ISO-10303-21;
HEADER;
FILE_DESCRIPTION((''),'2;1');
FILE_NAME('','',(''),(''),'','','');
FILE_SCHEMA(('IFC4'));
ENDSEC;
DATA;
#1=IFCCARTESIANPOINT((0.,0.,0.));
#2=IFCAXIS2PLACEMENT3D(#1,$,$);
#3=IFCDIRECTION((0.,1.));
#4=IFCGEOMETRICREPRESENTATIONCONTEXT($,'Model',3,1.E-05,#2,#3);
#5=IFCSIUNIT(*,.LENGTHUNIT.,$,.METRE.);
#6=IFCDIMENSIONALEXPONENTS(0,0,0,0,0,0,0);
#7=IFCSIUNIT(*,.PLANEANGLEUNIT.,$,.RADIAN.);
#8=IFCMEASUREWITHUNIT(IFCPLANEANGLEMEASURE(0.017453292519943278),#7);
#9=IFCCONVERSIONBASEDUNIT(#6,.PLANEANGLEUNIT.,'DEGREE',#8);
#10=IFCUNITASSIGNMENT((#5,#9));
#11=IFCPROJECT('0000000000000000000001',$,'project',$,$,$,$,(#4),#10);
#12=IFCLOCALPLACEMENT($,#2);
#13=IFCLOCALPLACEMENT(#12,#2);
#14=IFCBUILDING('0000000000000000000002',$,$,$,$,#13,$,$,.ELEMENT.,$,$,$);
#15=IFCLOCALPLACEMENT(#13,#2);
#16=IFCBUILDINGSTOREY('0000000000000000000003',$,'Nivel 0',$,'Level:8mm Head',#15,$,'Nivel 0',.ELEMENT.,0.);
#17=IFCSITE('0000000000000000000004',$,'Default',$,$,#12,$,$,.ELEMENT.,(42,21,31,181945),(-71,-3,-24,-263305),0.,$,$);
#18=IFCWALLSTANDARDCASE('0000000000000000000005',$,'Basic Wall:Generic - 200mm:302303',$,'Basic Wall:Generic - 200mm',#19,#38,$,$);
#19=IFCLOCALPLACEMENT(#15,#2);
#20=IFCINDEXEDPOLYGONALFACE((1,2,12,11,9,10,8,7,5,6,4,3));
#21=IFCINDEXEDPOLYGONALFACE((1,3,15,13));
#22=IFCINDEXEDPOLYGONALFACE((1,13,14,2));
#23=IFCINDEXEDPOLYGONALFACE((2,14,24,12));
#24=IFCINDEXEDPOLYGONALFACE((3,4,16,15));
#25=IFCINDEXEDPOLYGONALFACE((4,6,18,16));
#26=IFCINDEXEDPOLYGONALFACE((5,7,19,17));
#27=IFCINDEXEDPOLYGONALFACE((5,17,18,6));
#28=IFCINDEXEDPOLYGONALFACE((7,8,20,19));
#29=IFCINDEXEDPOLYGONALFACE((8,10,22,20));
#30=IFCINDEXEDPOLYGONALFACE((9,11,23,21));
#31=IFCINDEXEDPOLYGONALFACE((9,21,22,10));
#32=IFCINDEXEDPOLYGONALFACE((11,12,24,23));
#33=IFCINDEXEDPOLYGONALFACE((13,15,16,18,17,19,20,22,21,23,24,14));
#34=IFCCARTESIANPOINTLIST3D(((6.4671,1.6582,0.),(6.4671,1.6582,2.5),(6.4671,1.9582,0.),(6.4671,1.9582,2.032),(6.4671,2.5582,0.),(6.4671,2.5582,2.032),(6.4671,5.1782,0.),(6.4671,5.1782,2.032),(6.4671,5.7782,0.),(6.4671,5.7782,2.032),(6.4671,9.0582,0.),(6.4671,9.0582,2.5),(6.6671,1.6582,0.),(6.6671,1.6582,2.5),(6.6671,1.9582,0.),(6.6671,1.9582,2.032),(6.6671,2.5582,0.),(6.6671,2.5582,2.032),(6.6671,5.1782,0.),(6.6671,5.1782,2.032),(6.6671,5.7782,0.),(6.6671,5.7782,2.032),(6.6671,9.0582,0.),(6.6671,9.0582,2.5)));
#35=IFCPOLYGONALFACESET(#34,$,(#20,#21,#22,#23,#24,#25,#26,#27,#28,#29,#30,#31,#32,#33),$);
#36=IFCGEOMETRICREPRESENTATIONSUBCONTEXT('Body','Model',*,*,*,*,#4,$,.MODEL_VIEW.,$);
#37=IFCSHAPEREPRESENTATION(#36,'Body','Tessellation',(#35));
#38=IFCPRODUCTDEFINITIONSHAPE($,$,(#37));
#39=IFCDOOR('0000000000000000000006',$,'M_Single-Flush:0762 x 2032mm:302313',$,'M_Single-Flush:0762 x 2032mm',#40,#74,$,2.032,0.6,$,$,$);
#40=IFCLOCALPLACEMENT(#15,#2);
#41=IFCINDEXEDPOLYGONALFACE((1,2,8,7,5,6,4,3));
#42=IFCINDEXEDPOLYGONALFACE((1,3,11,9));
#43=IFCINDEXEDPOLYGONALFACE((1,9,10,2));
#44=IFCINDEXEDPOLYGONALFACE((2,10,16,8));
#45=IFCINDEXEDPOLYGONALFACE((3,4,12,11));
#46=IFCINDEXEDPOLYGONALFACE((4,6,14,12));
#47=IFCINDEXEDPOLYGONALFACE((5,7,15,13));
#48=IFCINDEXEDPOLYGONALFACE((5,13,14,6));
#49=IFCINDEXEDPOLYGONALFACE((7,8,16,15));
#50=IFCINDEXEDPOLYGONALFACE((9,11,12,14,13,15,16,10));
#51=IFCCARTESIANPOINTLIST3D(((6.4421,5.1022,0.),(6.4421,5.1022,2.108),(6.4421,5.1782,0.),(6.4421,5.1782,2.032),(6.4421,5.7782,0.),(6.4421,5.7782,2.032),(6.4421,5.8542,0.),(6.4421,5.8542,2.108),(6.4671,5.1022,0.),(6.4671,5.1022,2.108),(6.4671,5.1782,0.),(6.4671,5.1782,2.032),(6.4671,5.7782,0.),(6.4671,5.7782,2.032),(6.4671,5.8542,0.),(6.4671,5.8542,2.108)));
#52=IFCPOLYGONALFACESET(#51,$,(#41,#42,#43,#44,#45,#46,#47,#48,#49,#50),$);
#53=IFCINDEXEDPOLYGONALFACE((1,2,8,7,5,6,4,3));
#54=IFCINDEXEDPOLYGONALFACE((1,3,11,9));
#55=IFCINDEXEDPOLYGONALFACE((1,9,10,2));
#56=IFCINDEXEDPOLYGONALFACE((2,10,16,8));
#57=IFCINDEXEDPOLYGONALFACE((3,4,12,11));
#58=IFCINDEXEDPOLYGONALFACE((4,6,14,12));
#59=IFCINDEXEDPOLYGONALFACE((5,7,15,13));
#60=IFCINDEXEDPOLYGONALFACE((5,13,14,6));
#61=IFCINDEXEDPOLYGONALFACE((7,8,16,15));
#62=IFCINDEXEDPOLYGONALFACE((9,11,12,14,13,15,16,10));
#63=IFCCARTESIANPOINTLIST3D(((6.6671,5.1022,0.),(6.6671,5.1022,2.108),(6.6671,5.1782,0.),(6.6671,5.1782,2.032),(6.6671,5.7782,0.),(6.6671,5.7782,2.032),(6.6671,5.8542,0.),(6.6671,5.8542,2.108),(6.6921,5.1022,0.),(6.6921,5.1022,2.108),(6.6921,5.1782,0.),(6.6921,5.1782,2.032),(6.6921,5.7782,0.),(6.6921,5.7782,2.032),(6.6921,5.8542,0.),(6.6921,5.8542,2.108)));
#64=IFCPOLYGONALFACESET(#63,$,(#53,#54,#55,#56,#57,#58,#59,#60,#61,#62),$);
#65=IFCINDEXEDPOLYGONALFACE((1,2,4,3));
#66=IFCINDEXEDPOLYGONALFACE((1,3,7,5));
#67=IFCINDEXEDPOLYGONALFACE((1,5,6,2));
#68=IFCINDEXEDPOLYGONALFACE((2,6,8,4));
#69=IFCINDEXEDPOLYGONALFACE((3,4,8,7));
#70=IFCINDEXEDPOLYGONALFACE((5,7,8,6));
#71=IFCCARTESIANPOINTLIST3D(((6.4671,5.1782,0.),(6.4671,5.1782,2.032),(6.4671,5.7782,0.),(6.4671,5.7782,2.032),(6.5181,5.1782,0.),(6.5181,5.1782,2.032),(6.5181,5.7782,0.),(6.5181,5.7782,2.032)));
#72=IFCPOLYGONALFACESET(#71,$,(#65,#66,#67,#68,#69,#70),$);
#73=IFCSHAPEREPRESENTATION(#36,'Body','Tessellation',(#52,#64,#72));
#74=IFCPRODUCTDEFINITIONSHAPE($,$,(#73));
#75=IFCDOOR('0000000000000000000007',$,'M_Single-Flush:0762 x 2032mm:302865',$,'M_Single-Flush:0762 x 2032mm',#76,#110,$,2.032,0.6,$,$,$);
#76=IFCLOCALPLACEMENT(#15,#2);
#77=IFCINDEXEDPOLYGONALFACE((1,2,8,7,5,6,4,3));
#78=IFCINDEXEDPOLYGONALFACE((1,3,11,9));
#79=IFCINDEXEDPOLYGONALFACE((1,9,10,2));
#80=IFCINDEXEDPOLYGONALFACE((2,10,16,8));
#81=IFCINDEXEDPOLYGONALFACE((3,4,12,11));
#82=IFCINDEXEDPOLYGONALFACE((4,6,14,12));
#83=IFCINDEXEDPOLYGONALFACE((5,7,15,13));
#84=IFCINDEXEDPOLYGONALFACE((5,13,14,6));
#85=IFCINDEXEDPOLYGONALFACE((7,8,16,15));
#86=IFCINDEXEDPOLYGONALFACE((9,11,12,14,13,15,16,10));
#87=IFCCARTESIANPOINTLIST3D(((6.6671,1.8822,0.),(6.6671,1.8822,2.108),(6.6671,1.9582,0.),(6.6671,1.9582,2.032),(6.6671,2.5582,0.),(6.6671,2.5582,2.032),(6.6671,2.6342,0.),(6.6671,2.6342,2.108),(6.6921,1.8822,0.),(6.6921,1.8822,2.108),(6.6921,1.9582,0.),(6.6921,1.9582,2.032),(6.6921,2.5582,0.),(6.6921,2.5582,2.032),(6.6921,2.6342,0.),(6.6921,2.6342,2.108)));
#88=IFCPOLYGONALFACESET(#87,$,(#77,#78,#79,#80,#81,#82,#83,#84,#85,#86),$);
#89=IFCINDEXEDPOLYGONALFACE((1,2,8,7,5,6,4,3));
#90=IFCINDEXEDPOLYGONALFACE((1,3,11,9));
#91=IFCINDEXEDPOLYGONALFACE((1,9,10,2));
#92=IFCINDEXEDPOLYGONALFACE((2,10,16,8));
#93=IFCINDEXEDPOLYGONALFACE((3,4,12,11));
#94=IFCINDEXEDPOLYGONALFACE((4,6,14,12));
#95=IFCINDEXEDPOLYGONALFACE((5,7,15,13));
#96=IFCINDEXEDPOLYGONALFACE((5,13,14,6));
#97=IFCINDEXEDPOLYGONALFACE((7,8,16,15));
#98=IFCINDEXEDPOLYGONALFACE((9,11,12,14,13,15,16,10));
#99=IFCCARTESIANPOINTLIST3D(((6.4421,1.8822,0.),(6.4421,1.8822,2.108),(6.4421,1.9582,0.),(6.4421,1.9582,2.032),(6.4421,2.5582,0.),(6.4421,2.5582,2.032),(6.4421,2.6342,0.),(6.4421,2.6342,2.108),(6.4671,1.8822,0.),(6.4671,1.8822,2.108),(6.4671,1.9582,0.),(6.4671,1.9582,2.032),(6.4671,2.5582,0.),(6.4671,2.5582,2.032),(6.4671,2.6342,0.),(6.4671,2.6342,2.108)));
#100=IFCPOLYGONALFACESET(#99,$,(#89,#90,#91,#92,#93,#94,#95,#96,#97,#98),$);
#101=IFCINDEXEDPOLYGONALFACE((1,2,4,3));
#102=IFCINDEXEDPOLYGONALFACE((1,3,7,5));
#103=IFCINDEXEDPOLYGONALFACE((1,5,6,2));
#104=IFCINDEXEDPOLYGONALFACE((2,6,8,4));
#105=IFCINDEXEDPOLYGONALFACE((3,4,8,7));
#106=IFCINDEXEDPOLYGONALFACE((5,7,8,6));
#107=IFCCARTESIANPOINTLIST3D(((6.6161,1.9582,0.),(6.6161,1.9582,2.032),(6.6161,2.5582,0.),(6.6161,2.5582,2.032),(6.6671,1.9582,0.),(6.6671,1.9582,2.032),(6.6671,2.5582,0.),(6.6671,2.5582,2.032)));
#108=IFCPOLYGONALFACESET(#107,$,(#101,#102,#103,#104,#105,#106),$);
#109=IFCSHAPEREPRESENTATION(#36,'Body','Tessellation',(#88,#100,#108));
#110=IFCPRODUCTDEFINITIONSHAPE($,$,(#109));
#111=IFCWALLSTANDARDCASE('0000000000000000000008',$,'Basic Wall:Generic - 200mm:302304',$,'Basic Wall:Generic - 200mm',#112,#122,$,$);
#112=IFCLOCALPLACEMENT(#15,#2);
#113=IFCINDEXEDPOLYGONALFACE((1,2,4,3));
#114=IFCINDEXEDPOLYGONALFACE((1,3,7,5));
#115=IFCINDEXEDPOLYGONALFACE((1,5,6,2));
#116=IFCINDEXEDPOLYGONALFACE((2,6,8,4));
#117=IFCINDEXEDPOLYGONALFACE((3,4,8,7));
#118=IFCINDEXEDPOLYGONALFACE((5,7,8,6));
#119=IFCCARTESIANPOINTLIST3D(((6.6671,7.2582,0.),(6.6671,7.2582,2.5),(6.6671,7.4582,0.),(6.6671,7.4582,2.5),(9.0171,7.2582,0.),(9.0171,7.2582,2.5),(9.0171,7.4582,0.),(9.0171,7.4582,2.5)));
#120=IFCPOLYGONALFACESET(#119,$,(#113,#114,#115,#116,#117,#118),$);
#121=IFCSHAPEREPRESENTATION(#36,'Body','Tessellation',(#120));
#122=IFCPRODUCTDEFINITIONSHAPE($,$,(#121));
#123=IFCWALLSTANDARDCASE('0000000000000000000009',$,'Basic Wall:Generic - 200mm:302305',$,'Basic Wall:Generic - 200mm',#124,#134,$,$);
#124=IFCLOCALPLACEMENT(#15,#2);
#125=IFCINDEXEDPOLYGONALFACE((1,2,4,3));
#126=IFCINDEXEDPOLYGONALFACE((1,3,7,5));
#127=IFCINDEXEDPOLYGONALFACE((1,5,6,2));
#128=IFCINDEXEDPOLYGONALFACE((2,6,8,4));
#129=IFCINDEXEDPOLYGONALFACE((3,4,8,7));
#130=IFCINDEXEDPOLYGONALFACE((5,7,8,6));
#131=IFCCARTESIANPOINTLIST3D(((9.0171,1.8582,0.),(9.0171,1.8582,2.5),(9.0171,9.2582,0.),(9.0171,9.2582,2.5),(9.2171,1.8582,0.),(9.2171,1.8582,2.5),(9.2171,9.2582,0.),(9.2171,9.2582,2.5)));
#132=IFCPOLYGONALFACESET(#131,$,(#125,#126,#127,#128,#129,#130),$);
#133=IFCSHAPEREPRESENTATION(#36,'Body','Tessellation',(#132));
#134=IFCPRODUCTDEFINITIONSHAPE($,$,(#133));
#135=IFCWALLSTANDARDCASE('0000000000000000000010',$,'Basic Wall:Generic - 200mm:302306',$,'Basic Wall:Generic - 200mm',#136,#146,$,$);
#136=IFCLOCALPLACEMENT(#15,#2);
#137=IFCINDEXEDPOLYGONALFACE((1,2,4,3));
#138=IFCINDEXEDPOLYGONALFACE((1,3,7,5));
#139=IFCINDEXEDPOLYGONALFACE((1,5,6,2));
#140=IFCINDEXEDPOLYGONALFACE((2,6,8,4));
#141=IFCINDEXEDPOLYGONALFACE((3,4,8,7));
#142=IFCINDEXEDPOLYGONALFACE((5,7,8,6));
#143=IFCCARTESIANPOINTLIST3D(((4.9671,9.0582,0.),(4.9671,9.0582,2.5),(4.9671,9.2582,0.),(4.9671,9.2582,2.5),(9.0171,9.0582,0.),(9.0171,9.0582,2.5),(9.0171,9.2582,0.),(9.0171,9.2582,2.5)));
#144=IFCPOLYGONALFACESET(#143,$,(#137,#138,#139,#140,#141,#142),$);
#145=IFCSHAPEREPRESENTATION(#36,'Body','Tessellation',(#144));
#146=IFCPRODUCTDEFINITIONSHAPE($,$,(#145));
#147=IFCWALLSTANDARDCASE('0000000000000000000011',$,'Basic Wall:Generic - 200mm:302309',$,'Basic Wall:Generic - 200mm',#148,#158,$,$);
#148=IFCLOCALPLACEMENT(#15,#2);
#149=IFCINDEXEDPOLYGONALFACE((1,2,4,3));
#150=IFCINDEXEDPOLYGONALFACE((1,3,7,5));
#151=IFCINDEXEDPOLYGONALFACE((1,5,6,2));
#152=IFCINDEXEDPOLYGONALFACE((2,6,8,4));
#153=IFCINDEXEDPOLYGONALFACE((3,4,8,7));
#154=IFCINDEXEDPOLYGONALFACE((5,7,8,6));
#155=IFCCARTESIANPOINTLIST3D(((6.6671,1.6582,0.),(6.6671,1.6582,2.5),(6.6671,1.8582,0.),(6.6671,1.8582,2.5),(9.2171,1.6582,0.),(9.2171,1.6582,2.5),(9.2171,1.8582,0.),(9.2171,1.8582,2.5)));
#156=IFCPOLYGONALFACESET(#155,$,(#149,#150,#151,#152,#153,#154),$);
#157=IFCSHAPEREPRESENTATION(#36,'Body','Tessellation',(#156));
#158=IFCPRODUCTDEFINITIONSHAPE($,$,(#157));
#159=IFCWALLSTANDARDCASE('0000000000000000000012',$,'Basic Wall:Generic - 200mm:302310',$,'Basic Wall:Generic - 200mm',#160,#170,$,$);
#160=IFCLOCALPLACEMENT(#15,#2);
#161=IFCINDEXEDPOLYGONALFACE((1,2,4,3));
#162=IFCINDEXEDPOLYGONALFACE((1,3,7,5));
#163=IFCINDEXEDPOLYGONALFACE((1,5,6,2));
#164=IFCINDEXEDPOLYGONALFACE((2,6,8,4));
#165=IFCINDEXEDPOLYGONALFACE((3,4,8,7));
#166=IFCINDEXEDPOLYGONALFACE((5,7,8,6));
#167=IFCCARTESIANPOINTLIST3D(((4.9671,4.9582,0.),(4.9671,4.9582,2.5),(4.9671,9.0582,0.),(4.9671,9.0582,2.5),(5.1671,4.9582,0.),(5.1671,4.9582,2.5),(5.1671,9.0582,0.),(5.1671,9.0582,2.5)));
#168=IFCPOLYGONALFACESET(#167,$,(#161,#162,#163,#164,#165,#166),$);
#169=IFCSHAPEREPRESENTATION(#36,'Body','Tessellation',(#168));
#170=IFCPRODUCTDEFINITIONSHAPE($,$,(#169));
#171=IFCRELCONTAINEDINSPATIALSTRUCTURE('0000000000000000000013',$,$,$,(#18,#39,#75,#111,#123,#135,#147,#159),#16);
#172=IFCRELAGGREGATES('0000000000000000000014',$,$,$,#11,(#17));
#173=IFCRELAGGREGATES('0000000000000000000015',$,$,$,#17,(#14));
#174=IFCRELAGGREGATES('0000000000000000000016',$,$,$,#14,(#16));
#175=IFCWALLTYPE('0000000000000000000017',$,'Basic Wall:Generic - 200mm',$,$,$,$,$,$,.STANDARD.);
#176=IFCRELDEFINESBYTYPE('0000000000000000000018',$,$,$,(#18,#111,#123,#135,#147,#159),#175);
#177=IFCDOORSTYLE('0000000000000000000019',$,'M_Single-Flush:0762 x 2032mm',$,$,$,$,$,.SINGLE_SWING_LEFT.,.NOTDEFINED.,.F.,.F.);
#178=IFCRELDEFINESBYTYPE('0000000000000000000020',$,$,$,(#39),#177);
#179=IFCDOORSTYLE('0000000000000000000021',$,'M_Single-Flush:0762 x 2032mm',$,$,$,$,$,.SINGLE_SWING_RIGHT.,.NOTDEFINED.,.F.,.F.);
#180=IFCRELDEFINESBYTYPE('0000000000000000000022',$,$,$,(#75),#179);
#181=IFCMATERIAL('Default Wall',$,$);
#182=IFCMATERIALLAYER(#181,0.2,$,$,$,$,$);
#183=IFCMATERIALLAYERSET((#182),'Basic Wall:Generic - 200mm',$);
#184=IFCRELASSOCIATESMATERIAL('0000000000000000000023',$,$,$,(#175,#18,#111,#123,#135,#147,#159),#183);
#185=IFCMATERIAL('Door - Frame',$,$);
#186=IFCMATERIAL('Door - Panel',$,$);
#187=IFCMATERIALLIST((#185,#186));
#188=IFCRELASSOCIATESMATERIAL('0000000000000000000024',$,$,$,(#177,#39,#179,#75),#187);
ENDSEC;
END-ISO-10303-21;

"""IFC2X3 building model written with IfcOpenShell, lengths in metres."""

from ifc_helpers import new_model, entity, si_unit, converted_unit, direction, frame, frame_2d, origin, place, context, subcontext, project, spatial, polyline, rectangle, outline, extrude, source, transform, mapped, material, material_list, layer, layer_set, layer_usage, type_object, type_shapes, element, fill, save


model = new_model("IFC2X3")

# Units and contexts
model_context = context("Model", 3, precision=1e-05, world=origin(), true_north=direction((0.0, 1.0)))
body_context = subcontext(model_context, "Body", "Model", "MODEL_VIEW")
ifc_project = project(units=[si_unit("LENGTHUNIT", "METRE"), converted_unit("PLANEANGLEUNIT", "DEGREE", entity("IfcPlaneAngleMeasure", 0.017453292519943278), si_unit("PLANEANGLEUNIT", "RADIAN"), dimensions=[0, 0, 0, 0, 0, 0, 0])], contexts=[model_context])

# Site, building, storey
site_placement = place(None, origin())
site = spatial("IfcSite", under=ifc_project, at=site_placement, Name="Default", CompositionType="ELEMENT", RefLatitude=(42, 21, 31, 181945), RefLongitude=(-71, -3, -24, -263305), RefElevation=0.0)
building_placement = place(site_placement, origin())
building = spatial("IfcBuilding", under=site, at=building_placement, CompositionType="ELEMENT")
storey_placement = place(building_placement, origin())
storey = spatial("IfcBuildingStorey", under=building, at=storey_placement, Name="Nivel 0", ObjectType="Level:8mm Head", LongName="Nivel 0", CompositionType="ELEMENT", Elevation=0.0)

# Wall, openings, doors
ifc_material_1 = material(Name="Default Wall")
ifc_layer = layer(ifc_material_1, 0.2)
ifc_layer_set = layer_set([ifc_layer], Name="Basic Wall:Generic - 200mm")
ifc_layer_usage_1 = layer_usage(ifc_layer_set, "AXIS2", "POSITIVE", -0.1)
wall_type = type_object("IfcWallType", Name="Basic Wall:Generic - 200mm", PredefinedType="STANDARD", material=ifc_layer_set)
wall_1_placement = place(storey_placement, frame((6.5671, 9.0582, 0.0), z_axis=(0.0, 0.0, 1.0), x_axis=(0.0, -1.0, 0.0)))
wall_1 = element("IfcWallStandardCase", 1, at=wall_1_placement, inside=storey, type_object=wall_type, material=ifc_layer_usage_1, Name="Basic Wall:Generic - 200mm:302303", ObjectType="Basic Wall:Generic - 200mm", context=body_context, shape_type="SweptSolid", body=[
    extrude(rectangle(XDim=7.4, YDim=0.2, at=frame_2d((3.7, 0.0), x_axis=(-1.0, 0.0))), origin(), (0.0, 0.0, 1.0), 2.5),
])
opening_1_placement = place(wall_1_placement, frame((3.88, 0.1, 0.0)))
opening_1 = element("IfcOpeningElement", 2, at=opening_1_placement, cuts=wall_1, ObjectType="Opening", context=body_context, shape_type="SweptSolid", body=[
    extrude(rectangle(XDim=0.6, YDim=2.032, at=frame_2d((1.016, 0.3), x_axis=(0.0, -1.0))), frame((0.0, 0.0, 0.0), z_axis=(0.0, -1.0, 0.0), x_axis=(0.0, 0.0, 1.0)), (0.0, 0.0, 1.0), 0.2),
])
opening_2_placement = place(wall_1_placement, frame((6.5, -0.1, 0.0)))
opening_2 = element("IfcOpeningElement", 3, at=opening_2_placement, cuts=wall_1, ObjectType="Opening", context=body_context, shape_type="SweptSolid", body=[
    extrude(rectangle(XDim=0.6, YDim=2.032, at=frame_2d((1.016, 0.3), x_axis=(0.0, 1.0))), frame((0.0, 0.0, 0.0), z_axis=(0.0, 1.0, 0.0), x_axis=(0.0, 0.0, 1.0)), (0.0, 0.0, 1.0), 0.2),
])
ifc_material_2 = material(Name="Door - Frame")
ifc_material_3 = material(Name="Door - Panel")
ifc_material_list = material_list([ifc_material_2, ifc_material_3])
door_style_1 = type_object("IfcDoorStyle", Name="M_Single-Flush:0762 x 2032mm", ConstructionType="NOTDEFINED", OperationType="SINGLE_SWING_LEFT", ParameterTakesPrecedence=False, Sizeable=False, material=ifc_material_list)
shared_shape_1 = source(origin(), body_context, "Body", "SweptSolid", [
    extrude(outline(polyline([(-0.376, -1.073), (0.376, -1.073), (0.376, 1.035), (0.3, 1.035), (0.3, -0.997), (-0.3, -0.997), (-0.3, 1.035), (-0.376, 1.035), (-0.376, -1.073)])), frame((0.3, 0.225, 1.035), z_axis=(0.0, -1.0, 0.0), x_axis=(-1.0, 0.0, 0.0)), (0.0, 0.0, 1.0), 0.025),
    extrude(outline(polyline([(-1.073, -0.376), (1.035, -0.376), (1.035, -0.3), (-0.997, -0.3), (-0.997, 0.3), (1.035, 0.3), (1.035, 0.376), (-1.073, 0.376), (-1.073, -0.376)])), frame((0.3, 0.0, 1.035), z_axis=(0.0, -1.0, 0.0), x_axis=(0.0, 0.0, -1.0)), (0.0, 0.0, 1.0), 0.025),
    extrude(rectangle(XDim=0.6, YDim=0.051, at=frame_2d((0.0, 0.0), x_axis=(1.0, 0.0))), frame((0.3, 0.1745, 0.0)), (0.0, 0.0, 1.0), 2.032),
])
type_shapes(door_style_1, [shared_shape_1])
door_1_placement = place(opening_1_placement, frame((0.0, 0.0, 0.0), z_axis=(0.0, 0.0, 1.0), x_axis=(-1.0, 0.0, 0.0)))
door_1 = element("IfcDoor", 4, at=door_1_placement, inside=storey, type_object=door_style_1, material=ifc_material_list, Name="M_Single-Flush:0762 x 2032mm:302313", ObjectType="M_Single-Flush:0762 x 2032mm", OverallHeight=2.032, OverallWidth=0.6, context=body_context, shape_type="MappedRepresentation", body=[
    mapped(shared_shape_1, transform((0.0, 0.0, 0.0), scale=1.0)),
])
fill(opening_1, door_1)
door_style_2 = type_object("IfcDoorStyle", Name="M_Single-Flush:0762 x 2032mm", ConstructionType="NOTDEFINED", OperationType="SINGLE_SWING_RIGHT", ParameterTakesPrecedence=False, Sizeable=False, material=ifc_material_list)
shared_shape_2 = source(origin(), body_context, "Body", "SweptSolid", [
    extrude(outline(polyline([(-0.376, -1.073), (0.376, -1.073), (0.376, 1.035), (0.3, 1.035), (0.3, -0.997), (-0.3, -0.997), (-0.3, 1.035), (-0.376, 1.035), (-0.376, -1.073)])), frame((0.3, 0.2, 1.035), z_axis=(0.0, 1.0, 0.0), x_axis=(1.0, 0.0, 0.0)), (0.0, 0.0, 1.0), 0.025),
    extrude(outline(polyline([(-1.073, -0.376), (1.035, -0.376), (1.035, -0.3), (-0.997, -0.3), (-0.997, 0.3), (1.035, 0.3), (1.035, 0.376), (-1.073, 0.376), (-1.073, -0.376)])), frame((0.3, -0.025, 1.035), z_axis=(0.0, 1.0, 0.0), x_axis=(0.0, 0.0, -1.0)), (0.0, 0.0, 1.0), 0.025),
    extrude(rectangle(XDim=0.051, YDim=0.6, at=frame_2d((0.0, 0.0), x_axis=(1.0, 0.0))), frame((0.3, 0.1745, 0.0), z_axis=(0.0, 0.0, 1.0), x_axis=(0.0, 1.0, 0.0)), (0.0, 0.0, 1.0), 2.032),
])
type_shapes(door_style_2, [shared_shape_2])
door_2_placement = place(opening_2_placement, origin())
door_2 = element("IfcDoor", 5, at=door_2_placement, inside=storey, type_object=door_style_2, material=ifc_material_list, Name="M_Single-Flush:0762 x 2032mm:302865", ObjectType="M_Single-Flush:0762 x 2032mm", OverallHeight=2.032, OverallWidth=0.6, context=body_context, shape_type="MappedRepresentation", body=[
    mapped(shared_shape_2, transform((0.0, 0.0, 0.0), scale=1.0)),
])
fill(opening_2, door_2)

# Walls
ifc_layer_usage_2 = layer_usage(ifc_layer_set, "AXIS2", "POSITIVE", -0.1)
wall_2_placement = place(storey_placement, frame((6.6671, 7.3582, 0.0)))
element("IfcWallStandardCase", 6, at=wall_2_placement, inside=storey, type_object=wall_type, material=ifc_layer_usage_2, Name="Basic Wall:Generic - 200mm:302304", ObjectType="Basic Wall:Generic - 200mm", context=body_context, shape_type="SweptSolid", body=[
    extrude(rectangle(XDim=2.35, YDim=0.2, at=frame_2d((1.175, 0.0), x_axis=(-1.0, 0.0))), origin(), (0.0, 0.0, 1.0), 2.5),
])
ifc_layer_usage_3 = layer_usage(ifc_layer_set, "AXIS2", "POSITIVE", -0.1)
wall_3_placement = place(storey_placement, frame((9.1171, 1.8582, 0.0), z_axis=(0.0, 0.0, 1.0), x_axis=(0.0, 1.0, 0.0)))
element("IfcWallStandardCase", 7, at=wall_3_placement, inside=storey, type_object=wall_type, material=ifc_layer_usage_3, Name="Basic Wall:Generic - 200mm:302305", ObjectType="Basic Wall:Generic - 200mm", context=body_context, shape_type="SweptSolid", body=[
    extrude(rectangle(XDim=7.4, YDim=0.2, at=frame_2d((3.7, 0.0), x_axis=(-1.0, 0.0))), origin(), (0.0, 0.0, 1.0), 2.5),
])
ifc_layer_usage_4 = layer_usage(ifc_layer_set, "AXIS2", "POSITIVE", -0.1)
wall_4_placement = place(storey_placement, frame((9.0171, 9.1582, 0.0), z_axis=(0.0, 0.0, 1.0), x_axis=(-1.0, 0.0, 0.0)))
element("IfcWallStandardCase", 8, at=wall_4_placement, inside=storey, type_object=wall_type, material=ifc_layer_usage_4, Name="Basic Wall:Generic - 200mm:302306", ObjectType="Basic Wall:Generic - 200mm", context=body_context, shape_type="SweptSolid", body=[
    extrude(rectangle(XDim=4.05, YDim=0.2, at=frame_2d((2.025, 0.0), x_axis=(-1.0, 0.0))), origin(), (0.0, 0.0, 1.0), 2.5),
])
ifc_layer_usage_5 = layer_usage(ifc_layer_set, "AXIS2", "NEGATIVE", 0.1)
wall_5_placement = place(storey_placement, frame((6.6671, 1.7582, 0.0)))
element("IfcWallStandardCase", 9, at=wall_5_placement, inside=storey, type_object=wall_type, material=ifc_layer_usage_5, Name="Basic Wall:Generic - 200mm:302309", ObjectType="Basic Wall:Generic - 200mm", context=body_context, shape_type="SweptSolid", body=[
    extrude(rectangle(XDim=2.55, YDim=0.2, at=frame_2d((1.275, 0.0), x_axis=(-1.0, 0.0))), origin(), (0.0, 0.0, 1.0), 2.5),
])
ifc_layer_usage_6 = layer_usage(ifc_layer_set, "AXIS2", "NEGATIVE", 0.1)
wall_6_placement = place(storey_placement, frame((5.0671, 9.0582, 0.0), z_axis=(0.0, 0.0, 1.0), x_axis=(0.0, -1.0, 0.0)))
element("IfcWallStandardCase", 10, at=wall_6_placement, inside=storey, type_object=wall_type, material=ifc_layer_usage_6, Name="Basic Wall:Generic - 200mm:302310", ObjectType="Basic Wall:Generic - 200mm", context=body_context, shape_type="SweptSolid", body=[
    extrude(rectangle(XDim=4.1, YDim=0.2, at=frame_2d((2.05, 0.0), x_axis=(-1.0, 0.0))), origin(), (0.0, 0.0, 1.0), 2.5),
])

save(model, "model.ifc")
